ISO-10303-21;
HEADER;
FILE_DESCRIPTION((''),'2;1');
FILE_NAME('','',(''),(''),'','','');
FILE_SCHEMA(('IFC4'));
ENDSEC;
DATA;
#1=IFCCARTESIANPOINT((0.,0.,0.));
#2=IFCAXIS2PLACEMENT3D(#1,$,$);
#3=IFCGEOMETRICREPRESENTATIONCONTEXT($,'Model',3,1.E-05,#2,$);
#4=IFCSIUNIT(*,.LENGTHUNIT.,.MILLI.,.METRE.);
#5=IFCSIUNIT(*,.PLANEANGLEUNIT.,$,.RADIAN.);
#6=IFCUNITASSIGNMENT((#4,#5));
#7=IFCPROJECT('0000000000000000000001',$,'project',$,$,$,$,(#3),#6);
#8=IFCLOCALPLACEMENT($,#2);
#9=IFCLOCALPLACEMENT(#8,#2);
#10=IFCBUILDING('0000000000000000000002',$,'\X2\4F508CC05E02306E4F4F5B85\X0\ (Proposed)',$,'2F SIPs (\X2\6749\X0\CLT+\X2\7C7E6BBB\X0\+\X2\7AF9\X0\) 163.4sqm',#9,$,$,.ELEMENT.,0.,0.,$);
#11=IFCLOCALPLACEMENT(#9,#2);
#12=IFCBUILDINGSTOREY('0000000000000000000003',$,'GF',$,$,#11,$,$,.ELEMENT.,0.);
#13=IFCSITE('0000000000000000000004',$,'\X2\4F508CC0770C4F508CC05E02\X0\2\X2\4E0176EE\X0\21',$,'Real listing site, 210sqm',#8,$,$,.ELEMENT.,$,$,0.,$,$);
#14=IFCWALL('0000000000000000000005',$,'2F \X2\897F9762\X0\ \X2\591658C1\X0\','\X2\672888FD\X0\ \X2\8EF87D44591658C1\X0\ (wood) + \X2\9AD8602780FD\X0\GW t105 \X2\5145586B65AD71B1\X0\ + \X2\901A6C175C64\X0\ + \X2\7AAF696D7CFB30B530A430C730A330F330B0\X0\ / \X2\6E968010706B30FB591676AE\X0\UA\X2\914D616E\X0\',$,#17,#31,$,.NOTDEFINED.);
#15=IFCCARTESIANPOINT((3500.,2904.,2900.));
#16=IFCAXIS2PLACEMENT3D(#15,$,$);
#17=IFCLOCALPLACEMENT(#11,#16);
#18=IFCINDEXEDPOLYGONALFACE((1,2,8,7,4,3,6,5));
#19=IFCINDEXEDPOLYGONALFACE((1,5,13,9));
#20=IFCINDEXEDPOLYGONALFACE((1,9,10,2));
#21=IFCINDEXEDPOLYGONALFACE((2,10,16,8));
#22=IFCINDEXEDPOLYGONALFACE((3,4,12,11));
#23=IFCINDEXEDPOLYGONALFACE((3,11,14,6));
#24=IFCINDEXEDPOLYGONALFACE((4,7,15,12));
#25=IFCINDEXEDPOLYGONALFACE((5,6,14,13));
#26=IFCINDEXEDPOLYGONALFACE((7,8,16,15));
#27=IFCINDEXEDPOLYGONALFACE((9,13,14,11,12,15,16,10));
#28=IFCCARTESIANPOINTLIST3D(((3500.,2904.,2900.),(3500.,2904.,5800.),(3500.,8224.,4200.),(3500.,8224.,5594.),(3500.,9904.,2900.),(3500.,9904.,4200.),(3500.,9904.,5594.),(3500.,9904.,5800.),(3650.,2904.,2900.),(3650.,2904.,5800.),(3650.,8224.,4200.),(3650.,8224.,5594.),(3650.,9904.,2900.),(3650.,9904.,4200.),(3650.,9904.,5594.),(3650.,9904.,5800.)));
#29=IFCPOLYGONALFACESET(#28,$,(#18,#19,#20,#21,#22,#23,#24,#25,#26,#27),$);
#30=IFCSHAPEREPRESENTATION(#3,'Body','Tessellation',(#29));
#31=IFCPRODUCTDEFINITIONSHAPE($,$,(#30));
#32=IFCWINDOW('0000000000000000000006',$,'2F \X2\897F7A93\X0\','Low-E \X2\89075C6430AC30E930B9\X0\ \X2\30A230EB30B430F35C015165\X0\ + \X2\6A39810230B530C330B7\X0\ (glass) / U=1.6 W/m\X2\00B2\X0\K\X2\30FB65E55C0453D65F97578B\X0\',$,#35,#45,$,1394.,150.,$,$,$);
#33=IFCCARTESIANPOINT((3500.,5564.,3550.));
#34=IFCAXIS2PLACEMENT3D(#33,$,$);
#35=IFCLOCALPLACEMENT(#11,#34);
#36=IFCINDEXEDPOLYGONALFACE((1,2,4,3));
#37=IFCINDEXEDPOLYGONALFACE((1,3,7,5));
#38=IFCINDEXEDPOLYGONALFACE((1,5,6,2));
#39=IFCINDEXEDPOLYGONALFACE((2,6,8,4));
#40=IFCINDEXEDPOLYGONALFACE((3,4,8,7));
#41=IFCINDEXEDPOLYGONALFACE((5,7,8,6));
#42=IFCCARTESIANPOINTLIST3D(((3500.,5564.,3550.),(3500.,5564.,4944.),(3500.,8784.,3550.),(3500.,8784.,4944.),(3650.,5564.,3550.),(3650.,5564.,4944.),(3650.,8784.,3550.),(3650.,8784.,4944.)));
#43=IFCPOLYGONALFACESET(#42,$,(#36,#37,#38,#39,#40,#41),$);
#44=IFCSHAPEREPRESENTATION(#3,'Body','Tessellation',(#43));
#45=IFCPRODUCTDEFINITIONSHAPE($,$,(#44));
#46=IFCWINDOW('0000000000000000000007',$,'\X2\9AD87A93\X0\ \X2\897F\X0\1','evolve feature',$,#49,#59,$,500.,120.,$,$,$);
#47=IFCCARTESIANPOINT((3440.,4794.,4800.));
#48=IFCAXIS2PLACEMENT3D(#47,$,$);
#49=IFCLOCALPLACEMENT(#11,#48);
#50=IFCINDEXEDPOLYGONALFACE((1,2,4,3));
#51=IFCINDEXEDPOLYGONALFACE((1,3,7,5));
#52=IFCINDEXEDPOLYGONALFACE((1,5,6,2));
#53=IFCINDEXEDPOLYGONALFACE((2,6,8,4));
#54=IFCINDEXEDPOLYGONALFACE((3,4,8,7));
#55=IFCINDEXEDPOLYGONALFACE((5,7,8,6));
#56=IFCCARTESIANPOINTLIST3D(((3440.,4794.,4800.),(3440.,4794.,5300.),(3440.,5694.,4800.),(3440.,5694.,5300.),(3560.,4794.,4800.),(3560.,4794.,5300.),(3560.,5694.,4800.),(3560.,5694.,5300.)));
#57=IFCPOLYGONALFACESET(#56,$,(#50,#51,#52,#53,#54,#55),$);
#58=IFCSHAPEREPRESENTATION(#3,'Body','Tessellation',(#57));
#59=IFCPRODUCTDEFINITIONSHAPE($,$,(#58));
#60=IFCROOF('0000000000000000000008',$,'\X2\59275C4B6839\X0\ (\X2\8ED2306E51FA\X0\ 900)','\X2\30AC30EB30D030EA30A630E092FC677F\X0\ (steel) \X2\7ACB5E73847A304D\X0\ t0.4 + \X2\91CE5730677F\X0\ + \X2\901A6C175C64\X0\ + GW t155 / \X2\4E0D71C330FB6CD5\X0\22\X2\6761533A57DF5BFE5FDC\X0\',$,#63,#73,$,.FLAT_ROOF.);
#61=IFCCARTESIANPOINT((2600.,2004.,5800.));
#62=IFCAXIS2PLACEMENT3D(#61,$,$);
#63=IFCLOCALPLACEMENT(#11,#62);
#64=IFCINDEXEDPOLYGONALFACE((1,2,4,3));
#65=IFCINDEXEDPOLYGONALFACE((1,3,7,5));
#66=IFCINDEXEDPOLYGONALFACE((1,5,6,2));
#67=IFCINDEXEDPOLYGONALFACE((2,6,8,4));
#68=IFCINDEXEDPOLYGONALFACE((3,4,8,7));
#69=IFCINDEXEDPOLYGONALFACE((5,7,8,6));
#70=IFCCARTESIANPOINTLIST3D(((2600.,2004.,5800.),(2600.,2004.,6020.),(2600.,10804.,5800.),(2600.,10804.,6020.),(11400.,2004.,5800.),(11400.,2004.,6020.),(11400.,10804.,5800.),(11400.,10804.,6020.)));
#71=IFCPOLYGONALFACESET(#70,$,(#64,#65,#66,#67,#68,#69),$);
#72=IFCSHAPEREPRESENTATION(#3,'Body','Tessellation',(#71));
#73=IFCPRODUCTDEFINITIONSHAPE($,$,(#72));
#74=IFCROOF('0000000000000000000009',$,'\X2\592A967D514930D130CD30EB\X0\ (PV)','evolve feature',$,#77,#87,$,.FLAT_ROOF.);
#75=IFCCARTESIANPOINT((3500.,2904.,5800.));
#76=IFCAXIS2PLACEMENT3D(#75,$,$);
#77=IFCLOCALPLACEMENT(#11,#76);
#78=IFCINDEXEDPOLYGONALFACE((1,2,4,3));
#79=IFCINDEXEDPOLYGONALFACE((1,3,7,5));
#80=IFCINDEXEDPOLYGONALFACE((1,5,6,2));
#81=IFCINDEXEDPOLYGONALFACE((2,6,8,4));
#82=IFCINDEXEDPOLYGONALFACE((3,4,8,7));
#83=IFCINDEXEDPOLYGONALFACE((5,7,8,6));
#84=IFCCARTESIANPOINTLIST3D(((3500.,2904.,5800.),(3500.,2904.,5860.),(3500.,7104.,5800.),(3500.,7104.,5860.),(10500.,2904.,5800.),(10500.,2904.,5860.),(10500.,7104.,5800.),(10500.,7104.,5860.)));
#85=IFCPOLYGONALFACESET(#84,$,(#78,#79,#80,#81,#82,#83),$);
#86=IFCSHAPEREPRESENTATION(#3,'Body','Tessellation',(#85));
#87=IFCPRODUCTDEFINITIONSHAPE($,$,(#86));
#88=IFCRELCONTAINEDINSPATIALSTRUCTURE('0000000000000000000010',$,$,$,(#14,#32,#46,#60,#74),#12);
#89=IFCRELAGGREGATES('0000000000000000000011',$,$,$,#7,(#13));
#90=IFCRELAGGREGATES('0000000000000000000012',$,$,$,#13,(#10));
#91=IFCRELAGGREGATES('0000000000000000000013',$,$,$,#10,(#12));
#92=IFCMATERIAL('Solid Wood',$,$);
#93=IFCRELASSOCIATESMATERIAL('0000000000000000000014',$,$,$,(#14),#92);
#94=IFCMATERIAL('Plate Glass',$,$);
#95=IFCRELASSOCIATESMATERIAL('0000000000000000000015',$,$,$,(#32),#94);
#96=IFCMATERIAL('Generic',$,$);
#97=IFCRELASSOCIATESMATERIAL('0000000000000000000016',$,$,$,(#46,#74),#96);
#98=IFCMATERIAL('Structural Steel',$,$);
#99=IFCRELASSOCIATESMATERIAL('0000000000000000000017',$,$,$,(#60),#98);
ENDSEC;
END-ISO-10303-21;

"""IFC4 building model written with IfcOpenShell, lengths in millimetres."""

from ifc_helpers import new_model, si_unit, frame, frame_2d, origin, place, context, project, spatial, rectangle, extrude, material, element, fill, save


model = new_model("IFC4")

# Units and contexts
model_context = context("Model", 3, precision=1e-05, world=origin())
ifc_project = project(units=[si_unit("LENGTHUNIT", "METRE", prefix="MILLI"), si_unit("PLANEANGLEUNIT", "RADIAN")], contexts=[model_context])

# Site, building, storey
site_placement = place(None, origin())
site = spatial("IfcSite", under=ifc_project, at=site_placement, Name="佐賀県佐賀市2丁目21", ObjectType="Real listing site, 210sqm", CompositionType="ELEMENT", RefElevation=0.0)
building_placement = place(site_placement, origin())
building = spatial("IfcBuilding", under=site, at=building_placement, Name="佐賀市の住宅 (Proposed)", ObjectType="2F SIPs (杉CLT+籾殻+竹) 163.4sqm", CompositionType="ELEMENT", ElevationOfRefHeight=0.0, ElevationOfTerrain=0.0)
storey_placement = place(building_placement, origin())
storey = spatial("IfcBuildingStorey", under=building, at=storey_placement, Name="GF", CompositionType="ELEMENT", Elevation=0.0)

# Shared definitions
ifc_material_1 = material(Name="Solid Wood")
ifc_material_2 = material(Name="Generic")

# Shared definitions
ifc_material_3 = material(Name="Plate Glass")

# Wall, openings, windows
wall_1_placement = place(storey_placement, frame((3500.0, 2904.0, 2900.0)))
wall_1 = element("IfcWall", 1, at=wall_1_placement, inside=storey, material=ifc_material_1, Name="2F 西面 外壁", Description="木製 軸組外壁 (wood) + 高性能GW t105 充填断熱 + 通気層 + 窯業系サイディング / 準耐火・外皮UA配慮", PredefinedType="NOTDEFINED", context=model_context, shape_type="SweptSolid", body=[
    extrude(rectangle(XDim=150.0, YDim=7000.0, at=frame_2d((75.0, 3500.0))), frame((3500.0, 2904.0, 2900.0)), (0.0, 0.0, 1.0), 2900.0),
])
opening_1_placement = place(storey_placement, frame((3500.0, 5564.0, 3550.0)))
opening_1 = element("IfcOpeningElement", 2, at=opening_1_placement, cuts=wall_1, PredefinedType="NOTDEFINED", context=model_context, shape_type="SweptSolid", body=[
    extrude(rectangle(XDim=150.0, YDim=3220.0, at=frame_2d((75.0, 1610.0))), frame((3500.0, 5564.0, 3550.0)), (0.0, 0.0, 1.0), 1394.0),
])
opening_2_placement = place(storey_placement, frame((3440.0, 4794.0, 4800.0)))
opening_2 = element("IfcOpeningElement", 3, at=opening_2_placement, cuts=wall_1, PredefinedType="NOTDEFINED", context=model_context, shape_type="SweptSolid", body=[
    extrude(rectangle(XDim=120.0, YDim=900.0, at=frame_2d((60.0, 450.0))), frame((3440.0, 4794.0, 4800.0)), (0.0, 0.0, 1.0), 500.0),
])
window_1_placement = place(storey_placement, frame((3500.0, 5564.0, 3550.0)))
window_1 = element("IfcWindow", 4, at=window_1_placement, inside=storey, material=ifc_material_3, Name="2F 西窓", Description="Low-E 複層ガラス アルゴン封入 + 樹脂サッシ (glass) / U=1.6 W/m²K・日射取得型", OverallHeight=1394.0, OverallWidth=150.0, context=model_context, shape_type="SweptSolid", body=[
    extrude(rectangle(XDim=150.0, YDim=3220.0, at=frame_2d((75.0, 1610.0))), frame((3500.0, 5564.0, 3550.0)), (0.0, 0.0, 1.0), 1394.0),
])
fill(opening_1, window_1)
window_2_placement = place(storey_placement, frame((3440.0, 4794.0, 4800.0)))
window_2 = element("IfcWindow", 5, at=window_2_placement, inside=storey, material=ifc_material_2, Name="高窓 西1", Description="evolve feature", OverallHeight=500.0, OverallWidth=120.0, context=model_context, shape_type="SweptSolid", body=[
    extrude(rectangle(XDim=120.0, YDim=900.0, at=frame_2d((60.0, 450.0))), frame((3440.0, 4794.0, 4800.0)), (0.0, 0.0, 1.0), 500.0),
])
fill(opening_2, window_2)

# Roofs
ifc_material_4 = material(Name="Structural Steel")
roof_1_placement = place(storey_placement, frame((2600.0, 2004.0, 5800.0)))
element("IfcRoof", 6, at=roof_1_placement, inside=storey, material=ifc_material_4, Name="大屋根 (軒の出 900)", Description="ガルバリウム鋼板 (steel) 立平葺き t0.4 + 野地板 + 通気層 + GW t155 / 不燃・法22条区域対応", PredefinedType="FLAT_ROOF", context=model_context, shape_type="SweptSolid", body=[
    extrude(rectangle(XDim=8800.0, YDim=8800.0, at=frame_2d((4400.0, 4400.0))), frame((2600.0, 2004.0, 5800.0)), (0.0, 0.0, 1.0), 220.0),
])
roof_2_placement = place(storey_placement, frame((3500.0, 2904.0, 5800.0)))
element("IfcRoof", 7, at=roof_2_placement, inside=storey, material=ifc_material_2, Name="太陽光パネル (PV)", Description="evolve feature", PredefinedType="FLAT_ROOF", context=model_context, shape_type="SweptSolid", body=[
    extrude(rectangle(XDim=7000.0, YDim=4200.0, at=frame_2d((3500.0, 2100.0))), frame((3500.0, 2904.0, 5800.0)), (0.0, 0.0, 1.0), 60.0),
])

save(model, "model.ifc")
